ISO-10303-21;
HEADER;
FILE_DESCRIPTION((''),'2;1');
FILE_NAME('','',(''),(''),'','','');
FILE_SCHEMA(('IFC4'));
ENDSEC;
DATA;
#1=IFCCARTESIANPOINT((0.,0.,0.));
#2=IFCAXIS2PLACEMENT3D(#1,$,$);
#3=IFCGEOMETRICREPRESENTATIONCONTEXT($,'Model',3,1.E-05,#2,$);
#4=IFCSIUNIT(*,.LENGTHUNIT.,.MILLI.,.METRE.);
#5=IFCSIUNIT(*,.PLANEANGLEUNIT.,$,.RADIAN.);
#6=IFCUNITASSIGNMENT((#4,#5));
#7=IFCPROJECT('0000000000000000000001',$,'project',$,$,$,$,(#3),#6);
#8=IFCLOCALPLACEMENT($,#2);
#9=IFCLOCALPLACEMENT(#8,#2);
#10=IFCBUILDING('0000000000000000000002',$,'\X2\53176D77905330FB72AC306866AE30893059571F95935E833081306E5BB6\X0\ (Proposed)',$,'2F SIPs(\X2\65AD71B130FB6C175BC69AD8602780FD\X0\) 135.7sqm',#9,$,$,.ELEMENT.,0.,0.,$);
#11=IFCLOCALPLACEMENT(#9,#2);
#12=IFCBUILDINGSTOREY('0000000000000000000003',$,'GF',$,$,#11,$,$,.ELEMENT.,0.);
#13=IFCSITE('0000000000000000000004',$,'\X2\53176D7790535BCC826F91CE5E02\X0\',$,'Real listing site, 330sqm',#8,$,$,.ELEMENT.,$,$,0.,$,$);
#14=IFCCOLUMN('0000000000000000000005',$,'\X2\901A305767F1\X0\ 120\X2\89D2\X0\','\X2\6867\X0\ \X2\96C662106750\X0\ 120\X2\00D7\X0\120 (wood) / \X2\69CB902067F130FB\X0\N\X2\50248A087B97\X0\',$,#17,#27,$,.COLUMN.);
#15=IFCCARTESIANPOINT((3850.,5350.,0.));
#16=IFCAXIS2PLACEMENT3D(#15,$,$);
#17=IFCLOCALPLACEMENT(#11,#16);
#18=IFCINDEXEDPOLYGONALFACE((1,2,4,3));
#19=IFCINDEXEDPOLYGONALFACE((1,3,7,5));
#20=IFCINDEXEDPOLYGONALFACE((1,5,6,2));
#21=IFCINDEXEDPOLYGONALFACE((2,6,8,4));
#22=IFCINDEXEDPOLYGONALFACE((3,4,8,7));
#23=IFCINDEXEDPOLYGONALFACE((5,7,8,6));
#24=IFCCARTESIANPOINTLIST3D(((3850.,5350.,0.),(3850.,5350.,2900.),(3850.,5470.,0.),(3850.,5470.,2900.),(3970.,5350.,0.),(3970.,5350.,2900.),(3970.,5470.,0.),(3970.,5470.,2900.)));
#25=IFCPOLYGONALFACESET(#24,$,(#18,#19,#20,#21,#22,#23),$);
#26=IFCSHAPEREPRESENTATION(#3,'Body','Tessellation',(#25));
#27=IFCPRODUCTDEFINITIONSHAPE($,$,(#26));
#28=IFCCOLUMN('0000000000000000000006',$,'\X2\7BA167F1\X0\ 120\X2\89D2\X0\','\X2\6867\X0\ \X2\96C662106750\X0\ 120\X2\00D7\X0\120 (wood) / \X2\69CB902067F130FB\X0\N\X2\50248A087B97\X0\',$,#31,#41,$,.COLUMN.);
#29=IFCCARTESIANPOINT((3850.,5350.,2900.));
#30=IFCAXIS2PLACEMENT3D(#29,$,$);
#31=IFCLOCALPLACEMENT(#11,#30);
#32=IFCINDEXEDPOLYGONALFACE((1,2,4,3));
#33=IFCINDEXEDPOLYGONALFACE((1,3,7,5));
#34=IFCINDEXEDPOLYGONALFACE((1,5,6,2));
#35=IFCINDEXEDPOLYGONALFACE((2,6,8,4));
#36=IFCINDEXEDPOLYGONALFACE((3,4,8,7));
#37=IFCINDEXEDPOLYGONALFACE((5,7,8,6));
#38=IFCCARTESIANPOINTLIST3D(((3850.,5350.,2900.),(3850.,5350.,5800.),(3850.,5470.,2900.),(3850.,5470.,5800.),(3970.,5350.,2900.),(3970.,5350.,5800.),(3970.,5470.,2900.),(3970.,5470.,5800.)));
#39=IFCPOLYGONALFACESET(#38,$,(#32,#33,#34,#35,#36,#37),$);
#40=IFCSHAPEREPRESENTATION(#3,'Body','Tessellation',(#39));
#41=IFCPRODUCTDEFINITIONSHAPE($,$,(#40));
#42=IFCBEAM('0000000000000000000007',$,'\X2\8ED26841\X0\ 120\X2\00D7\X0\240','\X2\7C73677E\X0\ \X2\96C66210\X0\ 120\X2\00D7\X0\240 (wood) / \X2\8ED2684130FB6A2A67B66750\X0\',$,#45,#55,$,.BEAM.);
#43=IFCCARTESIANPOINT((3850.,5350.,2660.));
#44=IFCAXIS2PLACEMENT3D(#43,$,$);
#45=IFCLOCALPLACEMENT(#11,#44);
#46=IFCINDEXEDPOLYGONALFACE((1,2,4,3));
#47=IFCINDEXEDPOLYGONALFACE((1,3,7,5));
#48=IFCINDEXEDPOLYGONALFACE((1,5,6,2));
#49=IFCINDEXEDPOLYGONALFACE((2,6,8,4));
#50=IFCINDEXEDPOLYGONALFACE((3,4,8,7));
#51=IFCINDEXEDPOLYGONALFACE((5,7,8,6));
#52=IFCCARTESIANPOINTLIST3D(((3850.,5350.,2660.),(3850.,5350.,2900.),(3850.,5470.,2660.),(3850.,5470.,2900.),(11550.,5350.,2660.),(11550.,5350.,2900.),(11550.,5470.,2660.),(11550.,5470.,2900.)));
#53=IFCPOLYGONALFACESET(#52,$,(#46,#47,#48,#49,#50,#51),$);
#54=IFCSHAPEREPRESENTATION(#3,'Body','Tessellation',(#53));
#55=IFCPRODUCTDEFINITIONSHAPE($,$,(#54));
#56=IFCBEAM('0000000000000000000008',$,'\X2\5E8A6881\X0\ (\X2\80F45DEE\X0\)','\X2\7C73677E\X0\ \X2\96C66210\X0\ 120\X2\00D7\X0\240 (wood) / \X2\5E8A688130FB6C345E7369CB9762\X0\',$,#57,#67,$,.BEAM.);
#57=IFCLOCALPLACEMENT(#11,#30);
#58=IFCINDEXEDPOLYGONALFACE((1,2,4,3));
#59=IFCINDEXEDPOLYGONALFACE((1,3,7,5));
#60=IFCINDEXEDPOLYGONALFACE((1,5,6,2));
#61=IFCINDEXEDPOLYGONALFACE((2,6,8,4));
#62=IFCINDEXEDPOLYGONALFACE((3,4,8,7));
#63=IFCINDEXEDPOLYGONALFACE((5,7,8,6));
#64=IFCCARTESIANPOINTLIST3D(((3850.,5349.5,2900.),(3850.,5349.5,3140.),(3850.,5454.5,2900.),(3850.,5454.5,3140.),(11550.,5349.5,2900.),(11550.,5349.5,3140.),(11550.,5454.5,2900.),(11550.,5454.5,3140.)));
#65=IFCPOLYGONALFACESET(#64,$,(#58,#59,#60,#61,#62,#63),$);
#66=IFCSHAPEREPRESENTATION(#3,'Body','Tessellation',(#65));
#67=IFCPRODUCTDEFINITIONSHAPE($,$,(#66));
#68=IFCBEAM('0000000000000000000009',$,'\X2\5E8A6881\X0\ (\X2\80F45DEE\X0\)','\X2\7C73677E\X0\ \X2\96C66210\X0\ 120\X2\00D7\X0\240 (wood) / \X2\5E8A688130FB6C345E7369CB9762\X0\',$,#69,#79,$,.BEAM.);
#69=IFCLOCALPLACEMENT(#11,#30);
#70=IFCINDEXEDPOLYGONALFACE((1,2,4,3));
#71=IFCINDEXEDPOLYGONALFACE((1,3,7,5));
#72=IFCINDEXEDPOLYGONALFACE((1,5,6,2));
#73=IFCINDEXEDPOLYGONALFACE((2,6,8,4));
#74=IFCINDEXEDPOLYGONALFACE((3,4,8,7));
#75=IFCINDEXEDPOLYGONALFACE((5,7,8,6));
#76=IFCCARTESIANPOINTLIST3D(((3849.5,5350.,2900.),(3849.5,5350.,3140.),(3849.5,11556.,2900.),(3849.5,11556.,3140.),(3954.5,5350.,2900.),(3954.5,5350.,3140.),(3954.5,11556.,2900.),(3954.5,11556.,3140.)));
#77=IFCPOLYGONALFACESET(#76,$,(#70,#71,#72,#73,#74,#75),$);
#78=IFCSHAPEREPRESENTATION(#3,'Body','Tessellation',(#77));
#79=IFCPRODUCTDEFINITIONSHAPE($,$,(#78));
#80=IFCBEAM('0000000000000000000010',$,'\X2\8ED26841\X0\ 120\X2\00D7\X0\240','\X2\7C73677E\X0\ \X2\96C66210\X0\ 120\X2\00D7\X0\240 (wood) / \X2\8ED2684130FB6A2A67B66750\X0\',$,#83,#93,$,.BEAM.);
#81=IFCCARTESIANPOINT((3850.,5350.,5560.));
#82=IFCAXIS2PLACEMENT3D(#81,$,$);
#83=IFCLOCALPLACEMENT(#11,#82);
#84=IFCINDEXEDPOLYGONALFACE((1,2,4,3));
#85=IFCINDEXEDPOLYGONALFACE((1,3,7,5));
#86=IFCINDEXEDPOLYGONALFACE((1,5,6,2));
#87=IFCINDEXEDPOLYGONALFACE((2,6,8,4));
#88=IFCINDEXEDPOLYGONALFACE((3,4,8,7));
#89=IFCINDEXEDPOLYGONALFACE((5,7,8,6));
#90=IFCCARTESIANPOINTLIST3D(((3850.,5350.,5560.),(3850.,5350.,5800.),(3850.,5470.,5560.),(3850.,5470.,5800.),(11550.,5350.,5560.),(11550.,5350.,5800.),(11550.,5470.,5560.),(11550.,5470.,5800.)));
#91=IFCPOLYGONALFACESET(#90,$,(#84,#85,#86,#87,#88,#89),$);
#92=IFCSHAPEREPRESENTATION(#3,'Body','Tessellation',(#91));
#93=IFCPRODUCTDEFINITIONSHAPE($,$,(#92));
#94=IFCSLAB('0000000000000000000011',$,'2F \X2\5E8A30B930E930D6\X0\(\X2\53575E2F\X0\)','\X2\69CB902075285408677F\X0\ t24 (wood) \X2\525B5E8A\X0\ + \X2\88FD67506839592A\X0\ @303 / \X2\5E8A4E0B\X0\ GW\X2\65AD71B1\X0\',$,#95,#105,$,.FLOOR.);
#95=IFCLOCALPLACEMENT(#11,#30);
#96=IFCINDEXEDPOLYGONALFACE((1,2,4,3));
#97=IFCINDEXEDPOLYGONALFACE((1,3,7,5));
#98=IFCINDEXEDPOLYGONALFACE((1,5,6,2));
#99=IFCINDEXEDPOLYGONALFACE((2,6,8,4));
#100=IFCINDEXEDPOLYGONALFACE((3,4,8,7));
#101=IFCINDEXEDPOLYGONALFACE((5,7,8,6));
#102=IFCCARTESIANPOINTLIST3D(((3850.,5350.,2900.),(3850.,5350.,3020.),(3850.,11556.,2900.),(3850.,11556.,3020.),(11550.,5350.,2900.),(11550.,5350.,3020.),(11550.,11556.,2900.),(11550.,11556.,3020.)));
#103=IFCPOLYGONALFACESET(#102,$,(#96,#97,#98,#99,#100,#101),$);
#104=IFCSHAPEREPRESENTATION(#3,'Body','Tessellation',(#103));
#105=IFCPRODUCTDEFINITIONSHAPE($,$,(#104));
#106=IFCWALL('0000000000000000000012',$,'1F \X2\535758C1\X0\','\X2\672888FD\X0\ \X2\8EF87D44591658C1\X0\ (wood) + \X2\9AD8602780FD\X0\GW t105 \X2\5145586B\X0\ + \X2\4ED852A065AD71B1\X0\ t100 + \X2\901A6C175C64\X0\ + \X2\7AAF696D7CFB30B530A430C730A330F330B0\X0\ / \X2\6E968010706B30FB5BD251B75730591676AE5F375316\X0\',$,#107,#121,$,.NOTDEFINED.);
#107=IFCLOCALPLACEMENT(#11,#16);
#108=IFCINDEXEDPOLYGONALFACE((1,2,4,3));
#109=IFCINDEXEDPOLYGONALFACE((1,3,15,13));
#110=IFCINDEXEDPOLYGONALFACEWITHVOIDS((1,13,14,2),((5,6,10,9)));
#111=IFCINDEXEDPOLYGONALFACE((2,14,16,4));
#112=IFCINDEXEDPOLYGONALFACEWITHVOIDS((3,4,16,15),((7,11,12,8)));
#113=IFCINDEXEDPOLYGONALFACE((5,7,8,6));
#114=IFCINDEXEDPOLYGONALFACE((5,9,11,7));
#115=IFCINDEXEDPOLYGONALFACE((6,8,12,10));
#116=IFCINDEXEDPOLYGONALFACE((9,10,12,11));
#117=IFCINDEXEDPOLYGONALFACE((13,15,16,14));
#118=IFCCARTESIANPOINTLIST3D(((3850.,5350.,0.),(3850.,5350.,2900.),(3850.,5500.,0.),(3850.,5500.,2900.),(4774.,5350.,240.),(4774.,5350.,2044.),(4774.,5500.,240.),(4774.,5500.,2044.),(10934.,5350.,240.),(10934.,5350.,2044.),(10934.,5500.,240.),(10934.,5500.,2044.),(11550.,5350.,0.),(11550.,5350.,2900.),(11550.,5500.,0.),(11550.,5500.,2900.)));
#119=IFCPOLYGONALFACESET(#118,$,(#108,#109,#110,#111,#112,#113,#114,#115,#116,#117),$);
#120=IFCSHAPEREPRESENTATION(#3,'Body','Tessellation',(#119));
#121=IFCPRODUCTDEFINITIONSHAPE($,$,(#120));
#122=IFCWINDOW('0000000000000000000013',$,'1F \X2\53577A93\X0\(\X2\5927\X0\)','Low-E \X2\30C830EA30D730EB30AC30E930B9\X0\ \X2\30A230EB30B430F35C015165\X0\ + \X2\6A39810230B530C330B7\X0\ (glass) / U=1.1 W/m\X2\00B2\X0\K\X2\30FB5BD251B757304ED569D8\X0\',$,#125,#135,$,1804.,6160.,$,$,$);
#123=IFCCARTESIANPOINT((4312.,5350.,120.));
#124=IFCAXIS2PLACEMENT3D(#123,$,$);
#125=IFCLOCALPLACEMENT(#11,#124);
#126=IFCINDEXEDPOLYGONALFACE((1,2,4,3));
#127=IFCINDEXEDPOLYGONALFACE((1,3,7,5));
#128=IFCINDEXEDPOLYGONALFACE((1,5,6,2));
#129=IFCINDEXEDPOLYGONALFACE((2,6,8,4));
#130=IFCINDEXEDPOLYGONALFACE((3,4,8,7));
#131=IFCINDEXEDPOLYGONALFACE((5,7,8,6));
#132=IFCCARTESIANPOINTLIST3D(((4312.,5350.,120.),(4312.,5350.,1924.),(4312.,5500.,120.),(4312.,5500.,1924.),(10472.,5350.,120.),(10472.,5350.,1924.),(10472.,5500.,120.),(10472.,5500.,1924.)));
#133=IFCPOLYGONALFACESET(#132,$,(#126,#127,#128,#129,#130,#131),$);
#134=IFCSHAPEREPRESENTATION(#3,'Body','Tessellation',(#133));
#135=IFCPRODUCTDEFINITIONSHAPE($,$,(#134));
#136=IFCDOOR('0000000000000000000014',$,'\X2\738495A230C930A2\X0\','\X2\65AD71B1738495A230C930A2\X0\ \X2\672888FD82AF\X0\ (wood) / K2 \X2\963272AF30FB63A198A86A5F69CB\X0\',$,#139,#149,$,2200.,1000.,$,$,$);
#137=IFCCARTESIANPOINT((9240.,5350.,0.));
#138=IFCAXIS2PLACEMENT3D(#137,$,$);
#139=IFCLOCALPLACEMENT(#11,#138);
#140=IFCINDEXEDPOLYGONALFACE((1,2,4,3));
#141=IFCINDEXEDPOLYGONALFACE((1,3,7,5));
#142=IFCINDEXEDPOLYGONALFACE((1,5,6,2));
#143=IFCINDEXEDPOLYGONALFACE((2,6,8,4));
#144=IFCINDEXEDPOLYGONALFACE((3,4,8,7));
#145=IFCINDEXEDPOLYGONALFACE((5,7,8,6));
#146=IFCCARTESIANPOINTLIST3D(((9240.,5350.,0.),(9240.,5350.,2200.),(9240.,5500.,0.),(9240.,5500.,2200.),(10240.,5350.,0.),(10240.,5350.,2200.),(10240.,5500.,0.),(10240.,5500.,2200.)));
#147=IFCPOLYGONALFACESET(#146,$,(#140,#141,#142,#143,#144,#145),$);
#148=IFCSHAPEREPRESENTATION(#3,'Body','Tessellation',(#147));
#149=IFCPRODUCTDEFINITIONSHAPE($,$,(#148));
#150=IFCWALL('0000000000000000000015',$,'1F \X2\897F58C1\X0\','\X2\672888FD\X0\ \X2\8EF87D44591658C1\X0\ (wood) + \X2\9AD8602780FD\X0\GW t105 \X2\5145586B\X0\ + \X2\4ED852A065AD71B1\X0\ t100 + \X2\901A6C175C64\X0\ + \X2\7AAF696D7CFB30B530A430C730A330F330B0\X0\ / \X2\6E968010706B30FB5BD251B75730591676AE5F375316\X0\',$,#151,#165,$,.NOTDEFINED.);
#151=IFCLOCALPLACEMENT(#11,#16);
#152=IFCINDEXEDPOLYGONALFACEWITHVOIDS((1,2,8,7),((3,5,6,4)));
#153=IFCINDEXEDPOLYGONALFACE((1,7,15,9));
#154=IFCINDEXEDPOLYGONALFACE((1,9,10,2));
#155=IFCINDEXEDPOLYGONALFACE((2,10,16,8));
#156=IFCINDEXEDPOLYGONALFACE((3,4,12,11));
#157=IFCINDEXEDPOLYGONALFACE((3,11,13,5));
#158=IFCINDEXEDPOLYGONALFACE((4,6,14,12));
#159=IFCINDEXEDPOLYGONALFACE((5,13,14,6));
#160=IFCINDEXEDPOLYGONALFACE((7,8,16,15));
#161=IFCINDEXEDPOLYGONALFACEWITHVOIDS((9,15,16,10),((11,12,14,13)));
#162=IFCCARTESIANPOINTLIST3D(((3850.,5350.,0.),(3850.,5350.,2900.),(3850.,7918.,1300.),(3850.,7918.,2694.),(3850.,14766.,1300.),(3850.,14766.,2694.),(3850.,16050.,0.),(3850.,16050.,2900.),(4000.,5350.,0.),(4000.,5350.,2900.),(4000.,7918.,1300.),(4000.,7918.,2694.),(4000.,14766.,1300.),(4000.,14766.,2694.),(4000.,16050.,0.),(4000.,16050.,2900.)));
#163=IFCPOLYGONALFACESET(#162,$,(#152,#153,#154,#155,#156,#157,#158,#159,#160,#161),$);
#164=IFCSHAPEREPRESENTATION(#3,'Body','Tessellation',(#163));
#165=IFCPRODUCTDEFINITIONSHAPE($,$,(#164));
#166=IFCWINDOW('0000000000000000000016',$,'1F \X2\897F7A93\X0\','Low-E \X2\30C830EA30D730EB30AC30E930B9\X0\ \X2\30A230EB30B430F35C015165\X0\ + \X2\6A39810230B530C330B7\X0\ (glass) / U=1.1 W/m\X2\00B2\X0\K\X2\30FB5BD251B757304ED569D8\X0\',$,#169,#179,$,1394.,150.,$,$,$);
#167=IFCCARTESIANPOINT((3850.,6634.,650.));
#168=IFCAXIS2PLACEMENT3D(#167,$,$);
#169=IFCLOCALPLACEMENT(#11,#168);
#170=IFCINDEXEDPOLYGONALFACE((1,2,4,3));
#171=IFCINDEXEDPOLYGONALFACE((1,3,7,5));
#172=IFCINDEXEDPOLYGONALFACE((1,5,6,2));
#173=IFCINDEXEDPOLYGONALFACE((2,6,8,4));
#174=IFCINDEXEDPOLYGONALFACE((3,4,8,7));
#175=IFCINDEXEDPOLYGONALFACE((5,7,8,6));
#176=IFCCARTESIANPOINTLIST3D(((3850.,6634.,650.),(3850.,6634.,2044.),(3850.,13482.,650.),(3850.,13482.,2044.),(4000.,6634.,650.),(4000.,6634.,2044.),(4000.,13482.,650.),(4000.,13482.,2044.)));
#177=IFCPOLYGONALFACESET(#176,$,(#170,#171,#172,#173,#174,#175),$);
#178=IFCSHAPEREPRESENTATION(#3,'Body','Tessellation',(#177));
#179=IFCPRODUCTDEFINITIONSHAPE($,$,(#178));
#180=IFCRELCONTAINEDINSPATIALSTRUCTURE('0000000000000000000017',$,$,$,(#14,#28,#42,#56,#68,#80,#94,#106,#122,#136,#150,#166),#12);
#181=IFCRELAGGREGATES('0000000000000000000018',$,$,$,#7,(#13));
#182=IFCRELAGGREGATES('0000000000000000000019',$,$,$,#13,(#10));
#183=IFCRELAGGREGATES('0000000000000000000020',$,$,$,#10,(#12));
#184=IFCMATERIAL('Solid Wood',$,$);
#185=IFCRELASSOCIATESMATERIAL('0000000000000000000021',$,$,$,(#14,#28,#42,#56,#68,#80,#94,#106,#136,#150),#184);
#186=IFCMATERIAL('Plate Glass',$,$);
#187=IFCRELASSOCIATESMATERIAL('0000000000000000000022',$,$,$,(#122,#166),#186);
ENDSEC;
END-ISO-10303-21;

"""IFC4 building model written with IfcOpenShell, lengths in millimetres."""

from ifc_helpers import new_model, si_unit, frame, frame_2d, origin, place, context, project, spatial, rectangle, extrude, material, element, fill, save


model = new_model("IFC4")

# Units and contexts
model_context = context("Model", 3, precision=1e-05, world=origin())
ifc_project = project(units=[si_unit("LENGTHUNIT", "METRE", prefix="MILLI"), si_unit("PLANEANGLEUNIT", "RADIAN")], contexts=[model_context])

# Site, building, storey
site_placement = place(None, origin())
site = spatial("IfcSite", under=ifc_project, at=site_placement, Name="北海道富良野市", ObjectType="Real listing site, 330sqm", CompositionType="ELEMENT", RefElevation=0.0)
building_placement = place(site_placement, origin())
building = spatial("IfcBuilding", under=site, at=building_placement, Name="北海道・犬と暮らす土間広めの家 (Proposed)", ObjectType="2F SIPs(断熱・気密高性能) 135.7sqm", CompositionType="ELEMENT", ElevationOfRefHeight=0.0, ElevationOfTerrain=0.0)
storey_placement = place(building_placement, origin())
storey = spatial("IfcBuildingStorey", under=building, at=storey_placement, Name="GF", CompositionType="ELEMENT", Elevation=0.0)

# Columns
ifc_material_1 = material(Name="Solid Wood")
column_1_placement = place(storey_placement, frame((3850.0, 5350.0, 0.0)))
element("IfcColumn", 1, at=column_1_placement, inside=storey, material=ifc_material_1, Name="通し柱 120角", Description="桧 集成材 120×120 (wood) / 構造柱・N値計算", PredefinedType="COLUMN", context=model_context, shape_type="SweptSolid", body=[
    extrude(rectangle(XDim=120.0, YDim=120.0, at=frame_2d((60.0, 60.0))), frame((3850.0, 5350.0, 0.0)), (0.0, 0.0, 1.0), 2900.0),
])
column_2_placement = place(storey_placement, frame((3850.0, 5350.0, 2900.0)))
element("IfcColumn", 2, at=column_2_placement, inside=storey, material=ifc_material_1, Name="管柱 120角", Description="桧 集成材 120×120 (wood) / 構造柱・N値計算", PredefinedType="COLUMN", context=model_context, shape_type="SweptSolid", body=[
    extrude(rectangle(XDim=120.0, YDim=120.0, at=frame_2d((60.0, 60.0))), frame((3850.0, 5350.0, 2900.0)), (0.0, 0.0, 1.0), 2900.0),
])

# Beams
beam_1_placement = place(storey_placement, frame((3850.0, 5350.0, 2660.0)))
element("IfcBeam", 3, at=beam_1_placement, inside=storey, material=ifc_material_1, Name="軒桁 120×240", Description="米松 集成 120×240 (wood) / 軒桁・横架材", PredefinedType="BEAM", context=model_context, shape_type="SweptSolid", body=[
    extrude(rectangle(XDim=7700.0, YDim=120.0, at=frame_2d((3850.0, 60.0))), frame((3850.0, 5350.0, 2660.0)), (0.0, 0.0, 1.0), 240.0),
])
beam_2_placement = place(storey_placement, frame((3850.0, 5350.0, 2900.0)))
element("IfcBeam", 4, at=beam_2_placement, inside=storey, material=ifc_material_1, Name="床梁 (胴差)", Description="米松 集成 120×240 (wood) / 床梁・水平構面", PredefinedType="BEAM", context=model_context, shape_type="SweptSolid", body=[
    extrude(rectangle(XDim=7700.0, YDim=105.0, at=frame_2d((3850.0, 52.0))), frame((3850.0, 5350.0, 2900.0)), (0.0, 0.0, 1.0), 240.0),
])
beam_3_placement = place(storey_placement, frame((3850.0, 5350.0, 2900.0)))
element("IfcBeam", 5, at=beam_3_placement, inside=storey, material=ifc_material_1, Name="床梁 (胴差)", Description="米松 集成 120×240 (wood) / 床梁・水平構面", PredefinedType="BEAM", context=model_context, shape_type="SweptSolid", body=[
    extrude(rectangle(XDim=105.0, YDim=6206.0, at=frame_2d((52.0, 3103.0))), frame((3850.0, 5350.0, 2900.0)), (0.0, 0.0, 1.0), 240.0),
])
beam_4_placement = place(storey_placement, frame((3850.0, 5350.0, 5560.0)))
element("IfcBeam", 6, at=beam_4_placement, inside=storey, material=ifc_material_1, Name="軒桁 120×240", Description="米松 集成 120×240 (wood) / 軒桁・横架材", PredefinedType="BEAM", context=model_context, shape_type="SweptSolid", body=[
    extrude(rectangle(XDim=7700.0, YDim=120.0, at=frame_2d((3850.0, 60.0))), frame((3850.0, 5350.0, 5560.0)), (0.0, 0.0, 1.0), 240.0),
])

# Slab
slab_1_placement = place(storey_placement, frame((3850.0, 5350.0, 2900.0)))
element("IfcSlab", 7, at=slab_1_placement, inside=storey, material=ifc_material_1, Name="2F 床スラブ(南帯)", Description="構造用合板 t24 (wood) 剛床 + 製材根太 @303 / 床下 GW断熱", PredefinedType="FLOOR", context=model_context, shape_type="SweptSolid", body=[
    extrude(rectangle(XDim=7700.0, YDim=6206.0, at=frame_2d((3850.0, 3103.0))), frame((3850.0, 5350.0, 2900.0)), (0.0, 0.0, 1.0), 120.0),
])

# Wall, openings, window, door
wall_1_placement = place(storey_placement, frame((3850.0, 5350.0, 0.0)))
wall_1 = element("IfcWall", 8, at=wall_1_placement, inside=storey, material=ifc_material_1, Name="1F 南壁", Description="木製 軸組外壁 (wood) + 高性能GW t105 充填 + 付加断熱 t100 + 通気層 + 窯業系サイディング / 準耐火・寒冷地外皮強化", PredefinedType="NOTDEFINED", context=model_context, shape_type="SweptSolid", body=[
    extrude(rectangle(XDim=7700.0, YDim=150.0, at=frame_2d((3850.0, 75.0))), frame((3850.0, 5350.0, 0.0)), (0.0, 0.0, 1.0), 2900.0),
])
opening_1_placement = place(storey_placement, frame((4312.0, 5350.0, 120.0)))
opening_1 = element("IfcOpeningElement", 9, at=opening_1_placement, cuts=wall_1, PredefinedType="NOTDEFINED", context=model_context, shape_type="SweptSolid", body=[
    extrude(rectangle(XDim=6160.0, YDim=150.0, at=frame_2d((3080.0, 75.0))), frame((4312.0, 5350.0, 120.0)), (0.0, 0.0, 1.0), 1804.0),
])
opening_2_placement = place(storey_placement, frame((9240.0, 5350.0, 0.0)))
opening_2 = element("IfcOpeningElement", 10, at=opening_2_placement, cuts=wall_1, PredefinedType="NOTDEFINED", context=model_context, shape_type="SweptSolid", body=[
    extrude(rectangle(XDim=1000.0, YDim=150.0, at=frame_2d((500.0, 75.0))), frame((9240.0, 5350.0, 0.0)), (0.0, 0.0, 1.0), 2200.0),
])
ifc_material_2 = material(Name="Plate Glass")
window_1_placement = place(storey_placement, frame((4312.0, 5350.0, 120.0)))
window_1 = element("IfcWindow", 11, at=window_1_placement, inside=storey, material=ifc_material_2, Name="1F 南窓(大)", Description="Low-E トリプルガラス アルゴン封入 + 樹脂サッシ (glass) / U=1.1 W/m²K・寒冷地仕様", OverallHeight=1804.0, OverallWidth=6160.0, context=model_context, shape_type="SweptSolid", body=[
    extrude(rectangle(XDim=6160.0, YDim=150.0, at=frame_2d((3080.0, 75.0))), frame((4312.0, 5350.0, 120.0)), (0.0, 0.0, 1.0), 1804.0),
])
fill(opening_1, window_1)
door_placement = place(storey_placement, frame((9240.0, 5350.0, 0.0)))
door = element("IfcDoor", 12, at=door_placement, inside=storey, material=ifc_material_1, Name="玄関ドア", Description="断熱玄関ドア 木製芯 (wood) / K2 防犯・採風機構", OverallHeight=2200.0, OverallWidth=1000.0, context=model_context, shape_type="SweptSolid", body=[
    extrude(rectangle(XDim=1000.0, YDim=150.0, at=frame_2d((500.0, 75.0))), frame((9240.0, 5350.0, 0.0)), (0.0, 0.0, 1.0), 2200.0),
])
fill(opening_2, door)

# Wall, opening, window
wall_2_placement = place(storey_placement, frame((3850.0, 5350.0, 0.0)))
wall_2 = element("IfcWall", 13, at=wall_2_placement, inside=storey, material=ifc_material_1, Name="1F 西壁", Description="木製 軸組外壁 (wood) + 高性能GW t105 充填 + 付加断熱 t100 + 通気層 + 窯業系サイディング / 準耐火・寒冷地外皮強化", PredefinedType="NOTDEFINED", context=model_context, shape_type="SweptSolid", body=[
    extrude(rectangle(XDim=150.0, YDim=10700.0, at=frame_2d((75.0, 5350.0))), frame((3850.0, 5350.0, 0.0)), (0.0, 0.0, 1.0), 2900.0),
])
opening_3_placement = place(storey_placement, frame((3850.0, 6634.0, 650.0)))
opening_3 = element("IfcOpeningElement", 14, at=opening_3_placement, cuts=wall_2, PredefinedType="NOTDEFINED", context=model_context, shape_type="SweptSolid", body=[
    extrude(rectangle(XDim=150.0, YDim=6848.0, at=frame_2d((75.0, 3424.0))), frame((3850.0, 6634.0, 650.0)), (0.0, 0.0, 1.0), 1394.0),
])
window_2_placement = place(storey_placement, frame((3850.0, 6634.0, 650.0)))
window_2 = element("IfcWindow", 15, at=window_2_placement, inside=storey, material=ifc_material_2, Name="1F 西窓", Description="Low-E トリプルガラス アルゴン封入 + 樹脂サッシ (glass) / U=1.1 W/m²K・寒冷地仕様", OverallHeight=1394.0, OverallWidth=150.0, context=model_context, shape_type="SweptSolid", body=[
    extrude(rectangle(XDim=150.0, YDim=6848.0, at=frame_2d((75.0, 3424.0))), frame((3850.0, 6634.0, 650.0)), (0.0, 0.0, 1.0), 1394.0),
])
fill(opening_3, window_2)

save(model, "model.ifc")
